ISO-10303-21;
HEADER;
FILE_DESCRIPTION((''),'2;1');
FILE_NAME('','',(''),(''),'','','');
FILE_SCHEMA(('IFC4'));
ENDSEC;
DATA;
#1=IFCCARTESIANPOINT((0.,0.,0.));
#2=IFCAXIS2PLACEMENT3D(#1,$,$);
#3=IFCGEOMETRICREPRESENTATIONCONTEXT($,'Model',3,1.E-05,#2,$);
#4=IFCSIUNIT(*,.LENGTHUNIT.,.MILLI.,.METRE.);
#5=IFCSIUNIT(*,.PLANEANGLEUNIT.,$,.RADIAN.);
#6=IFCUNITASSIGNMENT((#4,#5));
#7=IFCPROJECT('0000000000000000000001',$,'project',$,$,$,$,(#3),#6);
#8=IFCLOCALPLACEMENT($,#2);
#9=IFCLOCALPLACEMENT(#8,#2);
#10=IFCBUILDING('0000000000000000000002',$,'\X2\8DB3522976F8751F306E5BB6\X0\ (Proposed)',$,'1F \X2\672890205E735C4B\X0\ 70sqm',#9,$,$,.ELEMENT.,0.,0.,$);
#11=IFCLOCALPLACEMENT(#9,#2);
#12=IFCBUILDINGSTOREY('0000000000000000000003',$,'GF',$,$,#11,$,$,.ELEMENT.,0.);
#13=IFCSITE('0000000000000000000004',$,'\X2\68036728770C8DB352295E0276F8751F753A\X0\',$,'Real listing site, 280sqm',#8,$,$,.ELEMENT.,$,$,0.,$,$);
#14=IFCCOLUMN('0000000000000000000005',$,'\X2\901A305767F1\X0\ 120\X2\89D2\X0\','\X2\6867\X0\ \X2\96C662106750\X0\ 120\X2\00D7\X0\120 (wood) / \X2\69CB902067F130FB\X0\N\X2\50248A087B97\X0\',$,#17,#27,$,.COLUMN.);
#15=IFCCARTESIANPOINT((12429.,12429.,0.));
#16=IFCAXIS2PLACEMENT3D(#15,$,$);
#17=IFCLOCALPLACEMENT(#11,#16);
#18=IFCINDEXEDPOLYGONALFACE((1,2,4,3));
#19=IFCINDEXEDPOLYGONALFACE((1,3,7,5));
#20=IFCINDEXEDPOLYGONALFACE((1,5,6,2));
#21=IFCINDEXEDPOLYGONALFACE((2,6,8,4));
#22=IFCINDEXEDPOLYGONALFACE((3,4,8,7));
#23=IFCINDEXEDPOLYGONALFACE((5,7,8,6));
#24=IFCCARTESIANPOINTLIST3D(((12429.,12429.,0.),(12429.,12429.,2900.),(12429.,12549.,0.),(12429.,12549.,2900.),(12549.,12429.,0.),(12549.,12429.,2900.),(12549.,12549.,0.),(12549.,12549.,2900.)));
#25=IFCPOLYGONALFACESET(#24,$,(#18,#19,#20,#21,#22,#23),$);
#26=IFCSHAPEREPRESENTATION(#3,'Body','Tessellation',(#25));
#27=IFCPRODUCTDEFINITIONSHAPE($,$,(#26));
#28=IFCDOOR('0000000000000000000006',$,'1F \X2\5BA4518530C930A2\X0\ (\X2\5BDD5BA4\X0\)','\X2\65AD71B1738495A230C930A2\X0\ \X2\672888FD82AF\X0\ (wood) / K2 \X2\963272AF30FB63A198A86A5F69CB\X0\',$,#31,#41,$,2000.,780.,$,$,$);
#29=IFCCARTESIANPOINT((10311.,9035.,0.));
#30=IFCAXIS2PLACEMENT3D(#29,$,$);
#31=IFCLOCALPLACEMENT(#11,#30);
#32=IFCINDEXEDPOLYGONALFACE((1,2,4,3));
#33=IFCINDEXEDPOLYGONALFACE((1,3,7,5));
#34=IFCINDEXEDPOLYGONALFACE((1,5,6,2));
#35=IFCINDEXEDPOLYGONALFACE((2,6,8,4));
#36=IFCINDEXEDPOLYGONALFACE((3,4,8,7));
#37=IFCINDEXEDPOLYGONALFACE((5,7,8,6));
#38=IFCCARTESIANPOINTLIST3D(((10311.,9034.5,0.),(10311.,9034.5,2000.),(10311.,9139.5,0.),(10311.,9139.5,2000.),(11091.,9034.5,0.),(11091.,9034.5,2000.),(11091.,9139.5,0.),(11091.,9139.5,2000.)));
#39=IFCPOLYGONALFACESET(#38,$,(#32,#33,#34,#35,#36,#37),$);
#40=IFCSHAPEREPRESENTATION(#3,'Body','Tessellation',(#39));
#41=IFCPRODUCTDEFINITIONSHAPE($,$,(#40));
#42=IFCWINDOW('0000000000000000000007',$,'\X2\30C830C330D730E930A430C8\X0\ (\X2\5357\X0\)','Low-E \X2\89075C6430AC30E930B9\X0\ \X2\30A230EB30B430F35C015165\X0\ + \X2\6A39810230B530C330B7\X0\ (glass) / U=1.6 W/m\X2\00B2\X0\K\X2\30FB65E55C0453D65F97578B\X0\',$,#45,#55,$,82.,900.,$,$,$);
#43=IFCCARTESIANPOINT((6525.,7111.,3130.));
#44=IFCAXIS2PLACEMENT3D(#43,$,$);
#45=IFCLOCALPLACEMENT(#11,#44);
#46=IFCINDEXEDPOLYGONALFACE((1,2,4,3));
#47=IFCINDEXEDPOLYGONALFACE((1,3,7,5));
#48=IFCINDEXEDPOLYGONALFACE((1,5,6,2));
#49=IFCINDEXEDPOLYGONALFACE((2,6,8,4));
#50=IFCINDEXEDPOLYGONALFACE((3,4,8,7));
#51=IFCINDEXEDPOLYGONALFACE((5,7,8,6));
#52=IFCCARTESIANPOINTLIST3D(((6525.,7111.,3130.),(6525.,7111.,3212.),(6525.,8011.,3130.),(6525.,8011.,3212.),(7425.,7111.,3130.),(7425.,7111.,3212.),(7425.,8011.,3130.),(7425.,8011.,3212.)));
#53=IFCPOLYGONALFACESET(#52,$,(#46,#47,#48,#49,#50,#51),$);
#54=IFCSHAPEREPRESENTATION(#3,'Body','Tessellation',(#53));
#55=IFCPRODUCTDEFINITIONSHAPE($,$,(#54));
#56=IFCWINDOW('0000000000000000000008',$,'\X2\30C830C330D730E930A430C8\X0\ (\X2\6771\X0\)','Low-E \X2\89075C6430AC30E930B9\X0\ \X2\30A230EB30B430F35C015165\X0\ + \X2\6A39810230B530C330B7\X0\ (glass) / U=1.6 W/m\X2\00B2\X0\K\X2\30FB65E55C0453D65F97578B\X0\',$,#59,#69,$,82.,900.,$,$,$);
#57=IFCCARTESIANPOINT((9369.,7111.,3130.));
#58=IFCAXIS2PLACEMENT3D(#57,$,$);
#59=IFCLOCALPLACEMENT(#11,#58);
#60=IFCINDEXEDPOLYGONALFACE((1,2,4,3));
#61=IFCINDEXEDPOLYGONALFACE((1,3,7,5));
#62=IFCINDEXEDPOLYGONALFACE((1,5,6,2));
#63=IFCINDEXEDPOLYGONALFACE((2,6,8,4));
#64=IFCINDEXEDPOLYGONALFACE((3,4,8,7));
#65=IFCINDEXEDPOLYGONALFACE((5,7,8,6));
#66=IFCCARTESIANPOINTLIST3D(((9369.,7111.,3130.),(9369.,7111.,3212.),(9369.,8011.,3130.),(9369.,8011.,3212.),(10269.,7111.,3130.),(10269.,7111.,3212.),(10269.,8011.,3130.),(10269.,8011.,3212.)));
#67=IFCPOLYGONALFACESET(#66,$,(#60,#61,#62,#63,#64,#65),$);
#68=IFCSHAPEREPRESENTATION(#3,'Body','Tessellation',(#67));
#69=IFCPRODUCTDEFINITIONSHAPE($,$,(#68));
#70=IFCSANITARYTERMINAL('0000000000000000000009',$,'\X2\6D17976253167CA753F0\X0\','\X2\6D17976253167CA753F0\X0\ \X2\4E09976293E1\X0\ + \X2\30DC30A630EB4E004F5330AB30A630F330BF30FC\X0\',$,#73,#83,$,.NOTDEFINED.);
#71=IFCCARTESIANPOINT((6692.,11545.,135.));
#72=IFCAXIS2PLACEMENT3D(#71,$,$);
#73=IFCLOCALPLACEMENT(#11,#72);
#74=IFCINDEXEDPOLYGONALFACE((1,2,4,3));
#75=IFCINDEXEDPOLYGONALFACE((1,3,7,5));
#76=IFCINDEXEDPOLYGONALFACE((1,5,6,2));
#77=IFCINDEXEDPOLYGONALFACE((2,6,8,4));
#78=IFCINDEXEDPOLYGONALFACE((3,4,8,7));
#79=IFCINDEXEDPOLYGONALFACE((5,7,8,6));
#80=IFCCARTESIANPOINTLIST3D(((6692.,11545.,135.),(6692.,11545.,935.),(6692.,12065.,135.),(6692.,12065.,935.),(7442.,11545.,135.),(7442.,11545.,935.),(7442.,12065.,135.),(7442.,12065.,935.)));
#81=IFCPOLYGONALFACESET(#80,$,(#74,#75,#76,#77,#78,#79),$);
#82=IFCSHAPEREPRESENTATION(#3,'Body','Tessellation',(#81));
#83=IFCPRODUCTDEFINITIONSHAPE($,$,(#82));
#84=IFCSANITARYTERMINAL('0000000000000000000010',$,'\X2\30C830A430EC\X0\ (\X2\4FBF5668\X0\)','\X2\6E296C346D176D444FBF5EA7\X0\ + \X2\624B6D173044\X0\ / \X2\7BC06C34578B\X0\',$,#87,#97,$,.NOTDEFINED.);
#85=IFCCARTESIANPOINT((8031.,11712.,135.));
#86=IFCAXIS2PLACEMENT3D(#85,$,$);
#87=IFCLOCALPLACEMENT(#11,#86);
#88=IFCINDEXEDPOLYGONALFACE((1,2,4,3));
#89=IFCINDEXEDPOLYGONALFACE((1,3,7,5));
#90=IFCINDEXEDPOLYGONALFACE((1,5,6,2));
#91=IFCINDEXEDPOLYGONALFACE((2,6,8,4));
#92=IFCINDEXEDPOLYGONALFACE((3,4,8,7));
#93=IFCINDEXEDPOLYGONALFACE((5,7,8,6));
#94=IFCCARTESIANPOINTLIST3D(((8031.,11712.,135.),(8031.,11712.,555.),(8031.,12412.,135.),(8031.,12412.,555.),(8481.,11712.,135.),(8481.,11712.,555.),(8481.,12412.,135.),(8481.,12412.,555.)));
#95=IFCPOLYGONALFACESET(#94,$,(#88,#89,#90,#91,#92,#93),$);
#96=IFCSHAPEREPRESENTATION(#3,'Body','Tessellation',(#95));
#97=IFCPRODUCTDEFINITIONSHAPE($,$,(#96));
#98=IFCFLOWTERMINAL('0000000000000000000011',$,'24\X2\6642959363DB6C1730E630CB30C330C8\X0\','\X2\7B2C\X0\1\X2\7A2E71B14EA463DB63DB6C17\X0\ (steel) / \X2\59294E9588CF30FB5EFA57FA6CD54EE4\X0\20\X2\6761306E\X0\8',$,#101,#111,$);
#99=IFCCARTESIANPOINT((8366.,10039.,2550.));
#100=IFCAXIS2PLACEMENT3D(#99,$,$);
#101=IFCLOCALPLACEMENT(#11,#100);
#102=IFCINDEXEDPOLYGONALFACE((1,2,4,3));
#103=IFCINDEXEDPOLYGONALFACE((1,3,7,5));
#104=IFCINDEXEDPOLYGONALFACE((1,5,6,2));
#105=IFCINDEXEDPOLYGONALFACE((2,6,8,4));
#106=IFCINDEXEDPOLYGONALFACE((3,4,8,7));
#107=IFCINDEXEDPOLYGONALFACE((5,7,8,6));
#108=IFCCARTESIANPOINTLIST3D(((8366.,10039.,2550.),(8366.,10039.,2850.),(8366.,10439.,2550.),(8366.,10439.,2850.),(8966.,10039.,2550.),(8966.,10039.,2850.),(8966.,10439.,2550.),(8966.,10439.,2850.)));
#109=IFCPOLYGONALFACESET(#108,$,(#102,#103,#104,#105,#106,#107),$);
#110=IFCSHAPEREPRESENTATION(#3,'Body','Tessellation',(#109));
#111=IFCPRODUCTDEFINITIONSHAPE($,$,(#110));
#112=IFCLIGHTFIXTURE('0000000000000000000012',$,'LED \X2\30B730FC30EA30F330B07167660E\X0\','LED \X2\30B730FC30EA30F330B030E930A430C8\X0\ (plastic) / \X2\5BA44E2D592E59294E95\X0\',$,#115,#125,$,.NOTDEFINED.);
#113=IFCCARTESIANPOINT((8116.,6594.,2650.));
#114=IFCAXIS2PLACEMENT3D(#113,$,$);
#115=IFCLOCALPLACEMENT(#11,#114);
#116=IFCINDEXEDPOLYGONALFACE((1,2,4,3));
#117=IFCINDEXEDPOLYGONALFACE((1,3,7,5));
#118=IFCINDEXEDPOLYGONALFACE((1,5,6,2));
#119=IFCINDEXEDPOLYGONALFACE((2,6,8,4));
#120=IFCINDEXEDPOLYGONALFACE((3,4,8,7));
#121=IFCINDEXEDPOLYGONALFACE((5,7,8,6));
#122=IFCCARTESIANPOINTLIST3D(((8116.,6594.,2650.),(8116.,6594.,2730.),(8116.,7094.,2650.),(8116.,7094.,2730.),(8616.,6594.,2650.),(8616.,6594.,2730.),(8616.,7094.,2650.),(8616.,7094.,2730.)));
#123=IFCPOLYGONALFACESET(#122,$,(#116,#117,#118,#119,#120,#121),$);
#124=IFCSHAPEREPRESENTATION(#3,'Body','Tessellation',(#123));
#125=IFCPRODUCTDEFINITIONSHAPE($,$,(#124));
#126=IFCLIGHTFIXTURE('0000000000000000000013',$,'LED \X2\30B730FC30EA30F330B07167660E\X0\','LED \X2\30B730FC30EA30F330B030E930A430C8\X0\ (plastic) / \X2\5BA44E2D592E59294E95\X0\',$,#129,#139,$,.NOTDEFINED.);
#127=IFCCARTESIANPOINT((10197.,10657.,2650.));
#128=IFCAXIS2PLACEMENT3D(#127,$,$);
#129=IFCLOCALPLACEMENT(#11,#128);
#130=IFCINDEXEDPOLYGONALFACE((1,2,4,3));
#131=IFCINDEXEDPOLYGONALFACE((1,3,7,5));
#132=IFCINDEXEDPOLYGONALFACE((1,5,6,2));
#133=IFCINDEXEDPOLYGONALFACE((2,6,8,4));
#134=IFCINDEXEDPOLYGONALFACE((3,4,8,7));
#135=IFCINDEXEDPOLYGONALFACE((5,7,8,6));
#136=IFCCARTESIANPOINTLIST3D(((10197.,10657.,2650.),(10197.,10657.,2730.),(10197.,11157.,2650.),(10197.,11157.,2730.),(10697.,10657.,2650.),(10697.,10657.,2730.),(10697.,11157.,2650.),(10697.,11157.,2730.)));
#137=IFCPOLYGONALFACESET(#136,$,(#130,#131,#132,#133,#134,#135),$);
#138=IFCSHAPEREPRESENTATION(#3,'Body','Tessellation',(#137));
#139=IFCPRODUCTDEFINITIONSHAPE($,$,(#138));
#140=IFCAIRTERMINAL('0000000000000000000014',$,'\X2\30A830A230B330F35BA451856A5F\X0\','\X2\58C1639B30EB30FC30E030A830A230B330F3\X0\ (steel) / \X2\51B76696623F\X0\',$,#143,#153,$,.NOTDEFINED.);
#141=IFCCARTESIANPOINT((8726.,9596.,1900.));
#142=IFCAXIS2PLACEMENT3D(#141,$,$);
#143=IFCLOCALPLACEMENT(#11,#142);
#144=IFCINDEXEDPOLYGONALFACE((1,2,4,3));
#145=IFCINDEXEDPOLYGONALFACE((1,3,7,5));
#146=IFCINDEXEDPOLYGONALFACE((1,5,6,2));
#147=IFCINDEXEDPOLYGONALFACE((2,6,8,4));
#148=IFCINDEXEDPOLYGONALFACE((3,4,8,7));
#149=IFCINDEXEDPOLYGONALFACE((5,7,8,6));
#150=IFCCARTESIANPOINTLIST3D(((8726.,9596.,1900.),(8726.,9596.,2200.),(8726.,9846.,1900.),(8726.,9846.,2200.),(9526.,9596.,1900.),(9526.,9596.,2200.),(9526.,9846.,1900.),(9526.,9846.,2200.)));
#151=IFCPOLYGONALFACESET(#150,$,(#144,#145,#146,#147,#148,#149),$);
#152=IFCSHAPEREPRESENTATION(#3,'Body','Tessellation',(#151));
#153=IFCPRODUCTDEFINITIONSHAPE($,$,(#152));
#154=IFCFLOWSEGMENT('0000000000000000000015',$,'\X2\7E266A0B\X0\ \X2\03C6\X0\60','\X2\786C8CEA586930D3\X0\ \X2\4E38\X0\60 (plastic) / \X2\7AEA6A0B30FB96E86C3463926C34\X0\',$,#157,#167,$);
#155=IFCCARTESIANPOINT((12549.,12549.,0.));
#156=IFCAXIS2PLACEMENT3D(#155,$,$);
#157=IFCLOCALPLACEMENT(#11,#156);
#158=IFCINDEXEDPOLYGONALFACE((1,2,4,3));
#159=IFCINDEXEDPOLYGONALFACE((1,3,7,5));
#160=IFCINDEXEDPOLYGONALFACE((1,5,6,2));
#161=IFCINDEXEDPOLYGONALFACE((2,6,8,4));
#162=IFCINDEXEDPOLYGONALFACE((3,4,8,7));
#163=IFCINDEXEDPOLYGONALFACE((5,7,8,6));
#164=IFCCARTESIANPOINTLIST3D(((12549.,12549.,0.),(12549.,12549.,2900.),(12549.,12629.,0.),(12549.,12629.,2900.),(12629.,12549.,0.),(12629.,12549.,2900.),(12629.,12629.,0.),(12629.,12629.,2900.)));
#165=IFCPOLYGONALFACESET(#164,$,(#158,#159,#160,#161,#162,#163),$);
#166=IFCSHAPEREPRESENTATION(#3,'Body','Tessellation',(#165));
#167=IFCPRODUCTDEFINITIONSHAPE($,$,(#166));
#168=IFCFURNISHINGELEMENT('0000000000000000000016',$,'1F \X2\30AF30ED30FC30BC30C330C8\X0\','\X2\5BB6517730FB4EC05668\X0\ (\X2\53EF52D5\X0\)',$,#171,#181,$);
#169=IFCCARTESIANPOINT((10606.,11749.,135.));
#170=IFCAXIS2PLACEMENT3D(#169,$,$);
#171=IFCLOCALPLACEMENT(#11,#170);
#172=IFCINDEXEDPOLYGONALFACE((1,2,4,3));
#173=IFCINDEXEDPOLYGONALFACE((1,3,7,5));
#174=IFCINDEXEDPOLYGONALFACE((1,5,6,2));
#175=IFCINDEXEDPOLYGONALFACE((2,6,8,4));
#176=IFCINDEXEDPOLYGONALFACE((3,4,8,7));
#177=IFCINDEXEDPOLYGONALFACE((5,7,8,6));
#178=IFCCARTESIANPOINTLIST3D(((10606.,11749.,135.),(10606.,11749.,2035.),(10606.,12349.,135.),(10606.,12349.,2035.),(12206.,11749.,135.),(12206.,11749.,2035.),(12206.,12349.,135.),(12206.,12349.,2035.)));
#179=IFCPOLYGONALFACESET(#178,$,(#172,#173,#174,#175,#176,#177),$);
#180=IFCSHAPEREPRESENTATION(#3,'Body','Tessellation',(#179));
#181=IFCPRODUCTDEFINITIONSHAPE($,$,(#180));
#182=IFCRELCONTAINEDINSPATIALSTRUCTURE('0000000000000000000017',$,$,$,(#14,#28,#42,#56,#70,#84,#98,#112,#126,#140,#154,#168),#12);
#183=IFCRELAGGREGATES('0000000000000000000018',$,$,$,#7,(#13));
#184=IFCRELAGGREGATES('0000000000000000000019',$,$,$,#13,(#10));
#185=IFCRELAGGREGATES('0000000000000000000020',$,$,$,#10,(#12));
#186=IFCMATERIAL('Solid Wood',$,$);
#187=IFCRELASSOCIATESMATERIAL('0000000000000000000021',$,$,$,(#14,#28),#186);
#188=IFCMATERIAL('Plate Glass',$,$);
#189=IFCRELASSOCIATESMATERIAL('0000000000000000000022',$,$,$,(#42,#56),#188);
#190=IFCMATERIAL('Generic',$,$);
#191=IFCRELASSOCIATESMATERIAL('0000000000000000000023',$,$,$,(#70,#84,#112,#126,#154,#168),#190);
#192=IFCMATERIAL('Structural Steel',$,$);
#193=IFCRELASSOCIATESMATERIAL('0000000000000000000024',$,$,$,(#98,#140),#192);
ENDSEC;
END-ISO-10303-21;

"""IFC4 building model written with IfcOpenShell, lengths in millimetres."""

from ifc_helpers import new_model, si_unit, frame, frame_2d, origin, place, context, project, spatial, rectangle, extrude, material, element, save


model = new_model("IFC4")

# Units and contexts
model_context = context("Model", 3, precision=1e-05, world=origin())
ifc_project = project(units=[si_unit("LENGTHUNIT", "METRE", prefix="MILLI"), si_unit("PLANEANGLEUNIT", "RADIAN")], contexts=[model_context])

# Site, building, storey
site_placement = place(None, origin())
site = spatial("IfcSite", under=ifc_project, at=site_placement, Name="栃木県足利市相生町", ObjectType="Real listing site, 280sqm", CompositionType="ELEMENT", RefElevation=0.0)
building_placement = place(site_placement, origin())
building = spatial("IfcBuilding", under=site, at=building_placement, Name="足利相生の家 (Proposed)", ObjectType="1F 木造平屋 70sqm", CompositionType="ELEMENT", ElevationOfRefHeight=0.0, ElevationOfTerrain=0.0)
storey_placement = place(building_placement, origin())
storey = spatial("IfcBuildingStorey", under=building, at=storey_placement, Name="GF", CompositionType="ELEMENT", Elevation=0.0)

# Column
ifc_material_1 = material(Name="Solid Wood")
column_1_placement = place(storey_placement, frame((12429.0, 12429.0, 0.0)))
element("IfcColumn", 1, at=column_1_placement, inside=storey, material=ifc_material_1, Name="通し柱 120角", Description="桧 集成材 120×120 (wood) / 構造柱・N値計算", PredefinedType="COLUMN", context=model_context, shape_type="SweptSolid", body=[
    extrude(rectangle(XDim=120.0, YDim=120.0, at=frame_2d((60.0, 60.0))), frame((12429.0, 12429.0, 0.0)), (0.0, 0.0, 1.0), 2900.0),
])

# Door
door_placement = place(storey_placement, frame((10311.0, 9035.0, 0.0)))
element("IfcDoor", 2, at=door_placement, inside=storey, material=ifc_material_1, Name="1F 室内ドア (寝室)", Description="断熱玄関ドア 木製芯 (wood) / K2 防犯・採風機構", OverallHeight=2000.0, OverallWidth=780.0, context=model_context, shape_type="SweptSolid", body=[
    extrude(rectangle(XDim=780.0, YDim=105.0, at=frame_2d((390.0, 52.0))), frame((10311.0, 9035.0, 0.0)), (0.0, 0.0, 1.0), 2000.0),
])

# Windows
ifc_material_2 = material(Name="Plate Glass")
window_1_placement = place(storey_placement, frame((6525.0, 7111.0, 3130.0)))
element("IfcWindow", 3, at=window_1_placement, inside=storey, material=ifc_material_2, Name="トップライト (南)", Description="Low-E 複層ガラス アルゴン封入 + 樹脂サッシ (glass) / U=1.6 W/m²K・日射取得型", OverallHeight=82.0, OverallWidth=900.0, context=model_context, shape_type="SweptSolid", body=[
    extrude(rectangle(XDim=900.0, YDim=900.0, at=frame_2d((450.0, 450.0))), frame((6525.0, 7111.0, 3130.0)), (0.0, 0.0, 1.0), 82.0),
])
window_2_placement = place(storey_placement, frame((9369.0, 7111.0, 3130.0)))
element("IfcWindow", 4, at=window_2_placement, inside=storey, material=ifc_material_2, Name="トップライト (東)", Description="Low-E 複層ガラス アルゴン封入 + 樹脂サッシ (glass) / U=1.6 W/m²K・日射取得型", OverallHeight=82.0, OverallWidth=900.0, context=model_context, shape_type="SweptSolid", body=[
    extrude(rectangle(XDim=900.0, YDim=900.0, at=frame_2d((450.0, 450.0))), frame((9369.0, 7111.0, 3130.0)), (0.0, 0.0, 1.0), 82.0),
])

# Sanitary terminals
ifc_material_3 = material(Name="Generic")
sanitary_terminal_1_placement = place(storey_placement, frame((6692.0, 11545.0, 135.0)))
element("IfcSanitaryTerminal", 5, at=sanitary_terminal_1_placement, inside=storey, material=ifc_material_3, Name="洗面化粧台", Description="洗面化粧台 三面鏡 + ボウル一体カウンター", PredefinedType="NOTDEFINED", context=model_context, shape_type="SweptSolid", body=[
    extrude(rectangle(XDim=750.0, YDim=520.0, at=frame_2d((375.0, 260.0))), frame((6692.0, 11545.0, 135.0)), (0.0, 0.0, 1.0), 800.0),
])
sanitary_terminal_2_placement = place(storey_placement, frame((8031.0, 11712.0, 135.0)))
element("IfcSanitaryTerminal", 6, at=sanitary_terminal_2_placement, inside=storey, material=ifc_material_3, Name="トイレ (便器)", Description="温水洗浄便座 + 手洗い / 節水型", PredefinedType="NOTDEFINED", context=model_context, shape_type="SweptSolid", body=[
    extrude(rectangle(XDim=450.0, YDim=700.0, at=frame_2d((225.0, 350.0))), frame((8031.0, 11712.0, 135.0)), (0.0, 0.0, 1.0), 420.0),
])

# Flow terminal
ifc_material_4 = material(Name="Structural Steel")
flow_terminal_placement = place(storey_placement, frame((8366.0, 10039.0, 2550.0)))
element("IfcFlowTerminal", 7, at=flow_terminal_placement, inside=storey, material=ifc_material_4, Name="24時間換気ユニット", Description="第1種熱交換換気 (steel) / 天井裏・建基法令20条の8", context=model_context, shape_type="SweptSolid", body=[
    extrude(rectangle(XDim=600.0, YDim=400.0, at=frame_2d((300.0, 200.0))), frame((8366.0, 10039.0, 2550.0)), (0.0, 0.0, 1.0), 300.0),
])

# Light fixtures
light_fixture_1_placement = place(storey_placement, frame((8116.0, 6594.0, 2650.0)))
element("IfcLightFixture", 8, at=light_fixture_1_placement, inside=storey, material=ifc_material_3, Name="LED シーリング照明", Description="LED シーリングライト (plastic) / 室中央天井", PredefinedType="NOTDEFINED", context=model_context, shape_type="SweptSolid", body=[
    extrude(rectangle(XDim=500.0, YDim=500.0, at=frame_2d((250.0, 250.0))), frame((8116.0, 6594.0, 2650.0)), (0.0, 0.0, 1.0), 80.0),
])
light_fixture_2_placement = place(storey_placement, frame((10197.0, 10657.0, 2650.0)))
element("IfcLightFixture", 9, at=light_fixture_2_placement, inside=storey, material=ifc_material_3, Name="LED シーリング照明", Description="LED シーリングライト (plastic) / 室中央天井", PredefinedType="NOTDEFINED", context=model_context, shape_type="SweptSolid", body=[
    extrude(rectangle(XDim=500.0, YDim=500.0, at=frame_2d((250.0, 250.0))), frame((10197.0, 10657.0, 2650.0)), (0.0, 0.0, 1.0), 80.0),
])

# Air terminal
air_terminal_placement = place(storey_placement, frame((8726.0, 9596.0, 1900.0)))
element("IfcAirTerminal", 10, at=air_terminal_placement, inside=storey, material=ifc_material_4, Name="エアコン室内機", Description="壁掛ルームエアコン (steel) / 冷暖房", PredefinedType="NOTDEFINED", context=model_context, shape_type="SweptSolid", body=[
    extrude(rectangle(XDim=800.0, YDim=250.0, at=frame_2d((400.0, 125.0))), frame((8726.0, 9596.0, 1900.0)), (0.0, 0.0, 1.0), 300.0),
])

# Flow segment
flow_segment_placement = place(storey_placement, frame((12549.0, 12549.0, 0.0)))
element("IfcFlowSegment", 11, at=flow_segment_placement, inside=storey, material=ifc_material_3, Name="縦樋 φ60", Description="硬質塩ビ 丸60 (plastic) / 竪樋・雨水排水", context=model_context, shape_type="SweptSolid", body=[
    extrude(rectangle(XDim=80.0, YDim=80.0, at=frame_2d((40.0, 40.0))), frame((12549.0, 12549.0, 0.0)), (0.0, 0.0, 1.0), 2900.0),
])

# Furnishing element
furnishing_placement = place(storey_placement, frame((10606.0, 11749.0, 135.0)))
element("IfcFurnishingElement", 12, at=furnishing_placement, inside=storey, material=ifc_material_3, Name="1F クローゼット", Description="家具・什器 (可動)", context=model_context, shape_type="SweptSolid", body=[
    extrude(rectangle(XDim=1600.0, YDim=600.0, at=frame_2d((800.0, 300.0))), frame((10606.0, 11749.0, 135.0)), (0.0, 0.0, 1.0), 1900.0),
])

save(model, "model.ifc")
